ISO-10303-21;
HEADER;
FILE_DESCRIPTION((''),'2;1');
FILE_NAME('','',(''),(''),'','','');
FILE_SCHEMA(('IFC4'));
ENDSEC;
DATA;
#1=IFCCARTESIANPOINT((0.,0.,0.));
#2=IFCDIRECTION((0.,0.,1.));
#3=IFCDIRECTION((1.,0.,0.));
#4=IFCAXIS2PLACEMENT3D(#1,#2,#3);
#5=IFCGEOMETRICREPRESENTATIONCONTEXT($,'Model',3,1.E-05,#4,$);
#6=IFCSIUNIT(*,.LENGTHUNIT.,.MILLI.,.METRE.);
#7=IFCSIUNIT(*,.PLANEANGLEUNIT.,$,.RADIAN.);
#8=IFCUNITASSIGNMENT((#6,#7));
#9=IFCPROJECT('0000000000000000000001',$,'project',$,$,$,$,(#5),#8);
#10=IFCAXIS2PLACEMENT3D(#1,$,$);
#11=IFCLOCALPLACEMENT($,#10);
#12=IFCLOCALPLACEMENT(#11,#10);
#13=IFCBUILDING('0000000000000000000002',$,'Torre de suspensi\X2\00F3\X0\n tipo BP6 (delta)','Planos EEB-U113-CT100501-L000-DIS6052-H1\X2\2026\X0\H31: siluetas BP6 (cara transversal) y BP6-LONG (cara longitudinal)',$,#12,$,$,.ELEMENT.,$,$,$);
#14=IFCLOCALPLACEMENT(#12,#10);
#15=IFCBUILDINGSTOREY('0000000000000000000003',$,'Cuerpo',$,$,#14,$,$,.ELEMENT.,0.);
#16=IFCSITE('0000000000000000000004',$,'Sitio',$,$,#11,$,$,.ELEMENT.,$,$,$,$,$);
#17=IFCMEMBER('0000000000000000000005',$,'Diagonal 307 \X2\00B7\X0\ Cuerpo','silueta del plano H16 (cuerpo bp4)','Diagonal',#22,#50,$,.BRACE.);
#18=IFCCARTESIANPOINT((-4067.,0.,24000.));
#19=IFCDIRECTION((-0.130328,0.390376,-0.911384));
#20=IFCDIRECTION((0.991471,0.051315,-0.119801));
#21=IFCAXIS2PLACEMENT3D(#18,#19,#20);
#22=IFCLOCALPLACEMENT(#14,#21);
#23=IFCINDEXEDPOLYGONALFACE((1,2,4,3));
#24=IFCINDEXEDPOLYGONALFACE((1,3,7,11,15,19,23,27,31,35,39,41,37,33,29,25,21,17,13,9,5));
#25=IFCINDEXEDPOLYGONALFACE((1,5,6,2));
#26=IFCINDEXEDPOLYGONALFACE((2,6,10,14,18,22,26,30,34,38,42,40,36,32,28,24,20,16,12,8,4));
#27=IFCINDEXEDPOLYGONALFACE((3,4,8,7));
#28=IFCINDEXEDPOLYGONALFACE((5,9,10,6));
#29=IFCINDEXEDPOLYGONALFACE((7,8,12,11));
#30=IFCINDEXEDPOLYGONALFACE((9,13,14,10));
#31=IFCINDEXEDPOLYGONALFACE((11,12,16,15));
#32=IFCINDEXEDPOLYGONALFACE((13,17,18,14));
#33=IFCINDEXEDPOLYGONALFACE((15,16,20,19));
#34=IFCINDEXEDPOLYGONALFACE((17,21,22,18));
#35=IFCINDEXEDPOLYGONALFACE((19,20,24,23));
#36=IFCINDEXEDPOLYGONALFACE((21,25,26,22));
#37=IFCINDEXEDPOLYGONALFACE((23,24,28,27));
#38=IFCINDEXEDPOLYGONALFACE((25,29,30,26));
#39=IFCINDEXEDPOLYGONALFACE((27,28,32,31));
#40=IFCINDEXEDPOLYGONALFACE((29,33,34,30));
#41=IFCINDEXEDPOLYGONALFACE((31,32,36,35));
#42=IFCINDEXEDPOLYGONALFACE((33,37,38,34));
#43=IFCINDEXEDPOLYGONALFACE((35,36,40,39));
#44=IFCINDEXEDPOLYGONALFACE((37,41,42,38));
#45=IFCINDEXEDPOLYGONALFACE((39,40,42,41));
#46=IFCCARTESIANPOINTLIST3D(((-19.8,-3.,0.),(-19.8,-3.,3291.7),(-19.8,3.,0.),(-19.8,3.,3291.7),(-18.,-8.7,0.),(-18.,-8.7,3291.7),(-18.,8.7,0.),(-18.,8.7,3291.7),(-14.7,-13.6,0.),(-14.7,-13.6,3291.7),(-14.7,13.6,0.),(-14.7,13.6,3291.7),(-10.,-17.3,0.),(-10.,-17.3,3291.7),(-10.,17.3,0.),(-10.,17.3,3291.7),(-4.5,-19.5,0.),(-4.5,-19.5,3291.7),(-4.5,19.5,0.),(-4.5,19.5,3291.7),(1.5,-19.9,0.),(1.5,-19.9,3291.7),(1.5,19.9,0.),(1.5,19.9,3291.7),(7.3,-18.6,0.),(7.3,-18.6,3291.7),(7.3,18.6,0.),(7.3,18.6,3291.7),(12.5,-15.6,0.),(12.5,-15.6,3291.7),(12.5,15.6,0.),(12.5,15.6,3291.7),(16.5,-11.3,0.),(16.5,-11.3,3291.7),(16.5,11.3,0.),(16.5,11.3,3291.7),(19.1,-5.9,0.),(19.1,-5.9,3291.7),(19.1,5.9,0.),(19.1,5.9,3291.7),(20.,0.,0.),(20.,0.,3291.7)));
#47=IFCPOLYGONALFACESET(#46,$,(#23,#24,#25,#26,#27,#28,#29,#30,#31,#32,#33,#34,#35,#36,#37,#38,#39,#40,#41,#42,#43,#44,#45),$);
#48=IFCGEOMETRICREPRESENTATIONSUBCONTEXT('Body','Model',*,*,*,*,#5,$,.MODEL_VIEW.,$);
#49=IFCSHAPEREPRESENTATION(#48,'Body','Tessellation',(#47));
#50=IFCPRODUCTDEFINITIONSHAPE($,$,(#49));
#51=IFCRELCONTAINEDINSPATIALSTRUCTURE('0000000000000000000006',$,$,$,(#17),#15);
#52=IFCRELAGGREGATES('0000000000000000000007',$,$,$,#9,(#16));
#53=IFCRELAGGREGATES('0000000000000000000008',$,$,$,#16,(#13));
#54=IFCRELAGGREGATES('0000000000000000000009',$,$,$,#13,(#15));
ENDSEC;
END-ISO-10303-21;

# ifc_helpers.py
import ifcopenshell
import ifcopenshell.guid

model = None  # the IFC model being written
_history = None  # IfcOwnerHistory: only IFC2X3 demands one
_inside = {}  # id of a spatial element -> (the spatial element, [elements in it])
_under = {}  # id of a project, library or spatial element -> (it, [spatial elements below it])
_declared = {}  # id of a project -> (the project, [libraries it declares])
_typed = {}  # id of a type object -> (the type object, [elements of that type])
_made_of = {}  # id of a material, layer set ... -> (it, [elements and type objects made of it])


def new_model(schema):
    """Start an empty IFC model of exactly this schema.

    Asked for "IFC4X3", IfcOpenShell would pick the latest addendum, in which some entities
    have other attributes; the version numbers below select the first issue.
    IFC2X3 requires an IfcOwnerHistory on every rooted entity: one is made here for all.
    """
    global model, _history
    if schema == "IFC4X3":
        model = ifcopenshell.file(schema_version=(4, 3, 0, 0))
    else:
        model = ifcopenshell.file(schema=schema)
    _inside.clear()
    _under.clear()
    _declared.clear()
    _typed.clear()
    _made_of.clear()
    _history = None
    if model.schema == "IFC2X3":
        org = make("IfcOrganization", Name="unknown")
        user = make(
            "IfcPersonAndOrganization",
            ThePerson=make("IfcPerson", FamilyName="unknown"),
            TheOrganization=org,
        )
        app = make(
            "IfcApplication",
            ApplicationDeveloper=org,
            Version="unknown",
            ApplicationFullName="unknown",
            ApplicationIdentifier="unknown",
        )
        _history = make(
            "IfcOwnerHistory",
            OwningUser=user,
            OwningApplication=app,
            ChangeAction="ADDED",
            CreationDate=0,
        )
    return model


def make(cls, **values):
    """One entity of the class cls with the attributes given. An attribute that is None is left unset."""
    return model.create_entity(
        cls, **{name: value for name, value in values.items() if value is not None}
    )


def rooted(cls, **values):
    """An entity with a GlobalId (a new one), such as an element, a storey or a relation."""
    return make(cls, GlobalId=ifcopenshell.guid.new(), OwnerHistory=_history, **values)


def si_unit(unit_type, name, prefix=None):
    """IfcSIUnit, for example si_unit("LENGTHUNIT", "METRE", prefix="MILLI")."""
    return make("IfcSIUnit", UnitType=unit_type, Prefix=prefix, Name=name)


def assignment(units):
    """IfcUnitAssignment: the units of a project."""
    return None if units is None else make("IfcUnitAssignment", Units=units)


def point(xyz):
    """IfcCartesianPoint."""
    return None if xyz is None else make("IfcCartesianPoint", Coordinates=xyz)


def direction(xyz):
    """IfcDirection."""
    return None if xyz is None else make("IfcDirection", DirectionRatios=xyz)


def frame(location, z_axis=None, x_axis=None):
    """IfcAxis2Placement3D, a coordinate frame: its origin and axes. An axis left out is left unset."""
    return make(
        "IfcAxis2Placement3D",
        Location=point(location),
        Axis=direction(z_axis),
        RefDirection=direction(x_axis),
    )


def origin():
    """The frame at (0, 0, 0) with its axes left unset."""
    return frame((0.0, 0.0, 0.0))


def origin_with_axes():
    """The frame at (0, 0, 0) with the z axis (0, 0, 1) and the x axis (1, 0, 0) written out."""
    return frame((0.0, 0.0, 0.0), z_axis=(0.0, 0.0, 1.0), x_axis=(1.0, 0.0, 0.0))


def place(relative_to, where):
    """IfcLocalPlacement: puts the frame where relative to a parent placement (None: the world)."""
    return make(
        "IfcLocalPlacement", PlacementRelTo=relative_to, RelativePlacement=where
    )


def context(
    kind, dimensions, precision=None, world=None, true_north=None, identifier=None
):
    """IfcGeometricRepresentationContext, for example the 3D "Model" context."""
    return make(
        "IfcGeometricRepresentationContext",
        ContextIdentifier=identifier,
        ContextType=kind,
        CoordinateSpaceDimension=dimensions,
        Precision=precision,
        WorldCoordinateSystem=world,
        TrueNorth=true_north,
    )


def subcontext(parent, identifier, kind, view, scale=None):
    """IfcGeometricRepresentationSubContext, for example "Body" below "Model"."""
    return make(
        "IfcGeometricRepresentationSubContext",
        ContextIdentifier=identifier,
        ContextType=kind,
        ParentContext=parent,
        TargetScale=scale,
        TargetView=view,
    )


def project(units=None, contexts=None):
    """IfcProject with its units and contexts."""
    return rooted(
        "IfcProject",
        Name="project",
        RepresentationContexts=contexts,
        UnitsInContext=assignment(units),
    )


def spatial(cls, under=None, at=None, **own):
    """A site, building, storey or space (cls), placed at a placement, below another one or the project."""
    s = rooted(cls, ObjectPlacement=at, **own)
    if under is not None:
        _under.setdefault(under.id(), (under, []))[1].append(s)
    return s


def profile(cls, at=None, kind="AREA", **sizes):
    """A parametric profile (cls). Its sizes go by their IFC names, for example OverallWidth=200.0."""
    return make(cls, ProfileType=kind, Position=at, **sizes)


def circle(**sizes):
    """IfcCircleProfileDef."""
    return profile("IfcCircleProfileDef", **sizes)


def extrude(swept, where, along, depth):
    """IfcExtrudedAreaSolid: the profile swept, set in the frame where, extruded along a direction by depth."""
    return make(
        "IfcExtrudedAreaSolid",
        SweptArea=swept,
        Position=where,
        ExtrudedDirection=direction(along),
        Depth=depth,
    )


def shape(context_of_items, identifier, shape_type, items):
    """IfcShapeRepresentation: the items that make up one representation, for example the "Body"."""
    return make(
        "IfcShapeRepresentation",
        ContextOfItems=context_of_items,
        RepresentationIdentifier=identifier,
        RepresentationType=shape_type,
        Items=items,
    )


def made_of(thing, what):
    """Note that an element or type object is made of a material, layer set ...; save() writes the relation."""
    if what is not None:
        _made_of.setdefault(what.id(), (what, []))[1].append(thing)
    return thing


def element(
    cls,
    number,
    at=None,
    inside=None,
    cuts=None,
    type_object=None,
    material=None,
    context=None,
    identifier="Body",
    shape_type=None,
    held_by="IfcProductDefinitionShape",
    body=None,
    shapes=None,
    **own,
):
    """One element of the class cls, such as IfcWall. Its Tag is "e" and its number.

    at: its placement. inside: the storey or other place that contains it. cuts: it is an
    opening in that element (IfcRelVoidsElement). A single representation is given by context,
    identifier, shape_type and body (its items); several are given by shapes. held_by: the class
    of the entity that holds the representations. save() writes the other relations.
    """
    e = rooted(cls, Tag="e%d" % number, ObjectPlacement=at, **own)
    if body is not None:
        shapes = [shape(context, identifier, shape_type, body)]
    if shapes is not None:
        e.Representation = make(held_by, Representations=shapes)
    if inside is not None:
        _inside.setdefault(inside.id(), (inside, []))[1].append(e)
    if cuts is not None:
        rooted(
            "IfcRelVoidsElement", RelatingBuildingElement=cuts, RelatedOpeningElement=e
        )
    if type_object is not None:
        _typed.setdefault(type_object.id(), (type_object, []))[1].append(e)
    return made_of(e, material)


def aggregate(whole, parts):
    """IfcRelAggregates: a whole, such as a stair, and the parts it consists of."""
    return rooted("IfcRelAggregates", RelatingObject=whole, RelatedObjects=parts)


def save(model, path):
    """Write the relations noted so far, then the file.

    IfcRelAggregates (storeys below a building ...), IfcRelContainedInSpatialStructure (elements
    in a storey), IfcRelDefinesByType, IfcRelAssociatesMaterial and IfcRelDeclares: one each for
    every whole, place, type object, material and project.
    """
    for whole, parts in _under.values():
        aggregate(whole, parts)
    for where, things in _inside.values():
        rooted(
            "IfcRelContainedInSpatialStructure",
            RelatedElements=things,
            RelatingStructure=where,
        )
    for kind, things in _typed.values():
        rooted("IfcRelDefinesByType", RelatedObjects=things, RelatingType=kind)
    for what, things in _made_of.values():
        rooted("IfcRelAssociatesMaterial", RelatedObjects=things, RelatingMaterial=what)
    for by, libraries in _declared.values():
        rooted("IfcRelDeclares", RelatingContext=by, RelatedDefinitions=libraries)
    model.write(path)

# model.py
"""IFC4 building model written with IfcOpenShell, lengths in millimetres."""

from ifc_helpers import new_model, si_unit, frame, origin, origin_with_axes, place, context, subcontext, project, spatial, circle, extrude, element, save


model = new_model("IFC4")

# Units and contexts
model_context = context("Model", 3, precision=1e-05, world=origin_with_axes())
body_context = subcontext(model_context, "Body", "Model", "MODEL_VIEW")
ifc_project = project(units=[si_unit("LENGTHUNIT", "METRE", prefix="MILLI"), si_unit("PLANEANGLEUNIT", "RADIAN")], contexts=[model_context])

# Site, building, storey
site_placement = place(None, origin())
site = spatial("IfcSite", under=ifc_project, at=site_placement, Name="Sitio", CompositionType="ELEMENT")
building_placement = place(site_placement, origin())
building = spatial("IfcBuilding", under=site, at=building_placement, Name="Torre de suspensión tipo BP6 (delta)", Description="Planos EEB-U113-CT100501-L000-DIS6052-H1…H31: siluetas BP6 (cara transversal) y BP6-LONG (cara longitudinal)", CompositionType="ELEMENT")
storey_placement = place(building_placement, origin())
storey = spatial("IfcBuildingStorey", under=building, at=storey_placement, Name="Cuerpo", CompositionType="ELEMENT", Elevation=0.0)

# Member
for number, where, z_axis, x_axis, name in (
    (1, (-4067.0, 0.0, 24000.0), (-0.130328, 0.390376, -0.911384), (0.991471, 0.051315, -0.119801), "Diagonal 307 · Cuerpo"),
):
    element("IfcMember", number, at=place(storey_placement, frame(where, z_axis=z_axis, x_axis=x_axis)), inside=storey, Name=name, Description="silueta del plano H16 (cuerpo bp4)", ObjectType="Diagonal", PredefinedType="BRACE", context=body_context, shape_type="SweptSolid", body=[
        extrude(circle(Radius=20.0), None, (0.0, 0.0, 1.0), 3291.7),
    ])

save(model, "model.ifc")
